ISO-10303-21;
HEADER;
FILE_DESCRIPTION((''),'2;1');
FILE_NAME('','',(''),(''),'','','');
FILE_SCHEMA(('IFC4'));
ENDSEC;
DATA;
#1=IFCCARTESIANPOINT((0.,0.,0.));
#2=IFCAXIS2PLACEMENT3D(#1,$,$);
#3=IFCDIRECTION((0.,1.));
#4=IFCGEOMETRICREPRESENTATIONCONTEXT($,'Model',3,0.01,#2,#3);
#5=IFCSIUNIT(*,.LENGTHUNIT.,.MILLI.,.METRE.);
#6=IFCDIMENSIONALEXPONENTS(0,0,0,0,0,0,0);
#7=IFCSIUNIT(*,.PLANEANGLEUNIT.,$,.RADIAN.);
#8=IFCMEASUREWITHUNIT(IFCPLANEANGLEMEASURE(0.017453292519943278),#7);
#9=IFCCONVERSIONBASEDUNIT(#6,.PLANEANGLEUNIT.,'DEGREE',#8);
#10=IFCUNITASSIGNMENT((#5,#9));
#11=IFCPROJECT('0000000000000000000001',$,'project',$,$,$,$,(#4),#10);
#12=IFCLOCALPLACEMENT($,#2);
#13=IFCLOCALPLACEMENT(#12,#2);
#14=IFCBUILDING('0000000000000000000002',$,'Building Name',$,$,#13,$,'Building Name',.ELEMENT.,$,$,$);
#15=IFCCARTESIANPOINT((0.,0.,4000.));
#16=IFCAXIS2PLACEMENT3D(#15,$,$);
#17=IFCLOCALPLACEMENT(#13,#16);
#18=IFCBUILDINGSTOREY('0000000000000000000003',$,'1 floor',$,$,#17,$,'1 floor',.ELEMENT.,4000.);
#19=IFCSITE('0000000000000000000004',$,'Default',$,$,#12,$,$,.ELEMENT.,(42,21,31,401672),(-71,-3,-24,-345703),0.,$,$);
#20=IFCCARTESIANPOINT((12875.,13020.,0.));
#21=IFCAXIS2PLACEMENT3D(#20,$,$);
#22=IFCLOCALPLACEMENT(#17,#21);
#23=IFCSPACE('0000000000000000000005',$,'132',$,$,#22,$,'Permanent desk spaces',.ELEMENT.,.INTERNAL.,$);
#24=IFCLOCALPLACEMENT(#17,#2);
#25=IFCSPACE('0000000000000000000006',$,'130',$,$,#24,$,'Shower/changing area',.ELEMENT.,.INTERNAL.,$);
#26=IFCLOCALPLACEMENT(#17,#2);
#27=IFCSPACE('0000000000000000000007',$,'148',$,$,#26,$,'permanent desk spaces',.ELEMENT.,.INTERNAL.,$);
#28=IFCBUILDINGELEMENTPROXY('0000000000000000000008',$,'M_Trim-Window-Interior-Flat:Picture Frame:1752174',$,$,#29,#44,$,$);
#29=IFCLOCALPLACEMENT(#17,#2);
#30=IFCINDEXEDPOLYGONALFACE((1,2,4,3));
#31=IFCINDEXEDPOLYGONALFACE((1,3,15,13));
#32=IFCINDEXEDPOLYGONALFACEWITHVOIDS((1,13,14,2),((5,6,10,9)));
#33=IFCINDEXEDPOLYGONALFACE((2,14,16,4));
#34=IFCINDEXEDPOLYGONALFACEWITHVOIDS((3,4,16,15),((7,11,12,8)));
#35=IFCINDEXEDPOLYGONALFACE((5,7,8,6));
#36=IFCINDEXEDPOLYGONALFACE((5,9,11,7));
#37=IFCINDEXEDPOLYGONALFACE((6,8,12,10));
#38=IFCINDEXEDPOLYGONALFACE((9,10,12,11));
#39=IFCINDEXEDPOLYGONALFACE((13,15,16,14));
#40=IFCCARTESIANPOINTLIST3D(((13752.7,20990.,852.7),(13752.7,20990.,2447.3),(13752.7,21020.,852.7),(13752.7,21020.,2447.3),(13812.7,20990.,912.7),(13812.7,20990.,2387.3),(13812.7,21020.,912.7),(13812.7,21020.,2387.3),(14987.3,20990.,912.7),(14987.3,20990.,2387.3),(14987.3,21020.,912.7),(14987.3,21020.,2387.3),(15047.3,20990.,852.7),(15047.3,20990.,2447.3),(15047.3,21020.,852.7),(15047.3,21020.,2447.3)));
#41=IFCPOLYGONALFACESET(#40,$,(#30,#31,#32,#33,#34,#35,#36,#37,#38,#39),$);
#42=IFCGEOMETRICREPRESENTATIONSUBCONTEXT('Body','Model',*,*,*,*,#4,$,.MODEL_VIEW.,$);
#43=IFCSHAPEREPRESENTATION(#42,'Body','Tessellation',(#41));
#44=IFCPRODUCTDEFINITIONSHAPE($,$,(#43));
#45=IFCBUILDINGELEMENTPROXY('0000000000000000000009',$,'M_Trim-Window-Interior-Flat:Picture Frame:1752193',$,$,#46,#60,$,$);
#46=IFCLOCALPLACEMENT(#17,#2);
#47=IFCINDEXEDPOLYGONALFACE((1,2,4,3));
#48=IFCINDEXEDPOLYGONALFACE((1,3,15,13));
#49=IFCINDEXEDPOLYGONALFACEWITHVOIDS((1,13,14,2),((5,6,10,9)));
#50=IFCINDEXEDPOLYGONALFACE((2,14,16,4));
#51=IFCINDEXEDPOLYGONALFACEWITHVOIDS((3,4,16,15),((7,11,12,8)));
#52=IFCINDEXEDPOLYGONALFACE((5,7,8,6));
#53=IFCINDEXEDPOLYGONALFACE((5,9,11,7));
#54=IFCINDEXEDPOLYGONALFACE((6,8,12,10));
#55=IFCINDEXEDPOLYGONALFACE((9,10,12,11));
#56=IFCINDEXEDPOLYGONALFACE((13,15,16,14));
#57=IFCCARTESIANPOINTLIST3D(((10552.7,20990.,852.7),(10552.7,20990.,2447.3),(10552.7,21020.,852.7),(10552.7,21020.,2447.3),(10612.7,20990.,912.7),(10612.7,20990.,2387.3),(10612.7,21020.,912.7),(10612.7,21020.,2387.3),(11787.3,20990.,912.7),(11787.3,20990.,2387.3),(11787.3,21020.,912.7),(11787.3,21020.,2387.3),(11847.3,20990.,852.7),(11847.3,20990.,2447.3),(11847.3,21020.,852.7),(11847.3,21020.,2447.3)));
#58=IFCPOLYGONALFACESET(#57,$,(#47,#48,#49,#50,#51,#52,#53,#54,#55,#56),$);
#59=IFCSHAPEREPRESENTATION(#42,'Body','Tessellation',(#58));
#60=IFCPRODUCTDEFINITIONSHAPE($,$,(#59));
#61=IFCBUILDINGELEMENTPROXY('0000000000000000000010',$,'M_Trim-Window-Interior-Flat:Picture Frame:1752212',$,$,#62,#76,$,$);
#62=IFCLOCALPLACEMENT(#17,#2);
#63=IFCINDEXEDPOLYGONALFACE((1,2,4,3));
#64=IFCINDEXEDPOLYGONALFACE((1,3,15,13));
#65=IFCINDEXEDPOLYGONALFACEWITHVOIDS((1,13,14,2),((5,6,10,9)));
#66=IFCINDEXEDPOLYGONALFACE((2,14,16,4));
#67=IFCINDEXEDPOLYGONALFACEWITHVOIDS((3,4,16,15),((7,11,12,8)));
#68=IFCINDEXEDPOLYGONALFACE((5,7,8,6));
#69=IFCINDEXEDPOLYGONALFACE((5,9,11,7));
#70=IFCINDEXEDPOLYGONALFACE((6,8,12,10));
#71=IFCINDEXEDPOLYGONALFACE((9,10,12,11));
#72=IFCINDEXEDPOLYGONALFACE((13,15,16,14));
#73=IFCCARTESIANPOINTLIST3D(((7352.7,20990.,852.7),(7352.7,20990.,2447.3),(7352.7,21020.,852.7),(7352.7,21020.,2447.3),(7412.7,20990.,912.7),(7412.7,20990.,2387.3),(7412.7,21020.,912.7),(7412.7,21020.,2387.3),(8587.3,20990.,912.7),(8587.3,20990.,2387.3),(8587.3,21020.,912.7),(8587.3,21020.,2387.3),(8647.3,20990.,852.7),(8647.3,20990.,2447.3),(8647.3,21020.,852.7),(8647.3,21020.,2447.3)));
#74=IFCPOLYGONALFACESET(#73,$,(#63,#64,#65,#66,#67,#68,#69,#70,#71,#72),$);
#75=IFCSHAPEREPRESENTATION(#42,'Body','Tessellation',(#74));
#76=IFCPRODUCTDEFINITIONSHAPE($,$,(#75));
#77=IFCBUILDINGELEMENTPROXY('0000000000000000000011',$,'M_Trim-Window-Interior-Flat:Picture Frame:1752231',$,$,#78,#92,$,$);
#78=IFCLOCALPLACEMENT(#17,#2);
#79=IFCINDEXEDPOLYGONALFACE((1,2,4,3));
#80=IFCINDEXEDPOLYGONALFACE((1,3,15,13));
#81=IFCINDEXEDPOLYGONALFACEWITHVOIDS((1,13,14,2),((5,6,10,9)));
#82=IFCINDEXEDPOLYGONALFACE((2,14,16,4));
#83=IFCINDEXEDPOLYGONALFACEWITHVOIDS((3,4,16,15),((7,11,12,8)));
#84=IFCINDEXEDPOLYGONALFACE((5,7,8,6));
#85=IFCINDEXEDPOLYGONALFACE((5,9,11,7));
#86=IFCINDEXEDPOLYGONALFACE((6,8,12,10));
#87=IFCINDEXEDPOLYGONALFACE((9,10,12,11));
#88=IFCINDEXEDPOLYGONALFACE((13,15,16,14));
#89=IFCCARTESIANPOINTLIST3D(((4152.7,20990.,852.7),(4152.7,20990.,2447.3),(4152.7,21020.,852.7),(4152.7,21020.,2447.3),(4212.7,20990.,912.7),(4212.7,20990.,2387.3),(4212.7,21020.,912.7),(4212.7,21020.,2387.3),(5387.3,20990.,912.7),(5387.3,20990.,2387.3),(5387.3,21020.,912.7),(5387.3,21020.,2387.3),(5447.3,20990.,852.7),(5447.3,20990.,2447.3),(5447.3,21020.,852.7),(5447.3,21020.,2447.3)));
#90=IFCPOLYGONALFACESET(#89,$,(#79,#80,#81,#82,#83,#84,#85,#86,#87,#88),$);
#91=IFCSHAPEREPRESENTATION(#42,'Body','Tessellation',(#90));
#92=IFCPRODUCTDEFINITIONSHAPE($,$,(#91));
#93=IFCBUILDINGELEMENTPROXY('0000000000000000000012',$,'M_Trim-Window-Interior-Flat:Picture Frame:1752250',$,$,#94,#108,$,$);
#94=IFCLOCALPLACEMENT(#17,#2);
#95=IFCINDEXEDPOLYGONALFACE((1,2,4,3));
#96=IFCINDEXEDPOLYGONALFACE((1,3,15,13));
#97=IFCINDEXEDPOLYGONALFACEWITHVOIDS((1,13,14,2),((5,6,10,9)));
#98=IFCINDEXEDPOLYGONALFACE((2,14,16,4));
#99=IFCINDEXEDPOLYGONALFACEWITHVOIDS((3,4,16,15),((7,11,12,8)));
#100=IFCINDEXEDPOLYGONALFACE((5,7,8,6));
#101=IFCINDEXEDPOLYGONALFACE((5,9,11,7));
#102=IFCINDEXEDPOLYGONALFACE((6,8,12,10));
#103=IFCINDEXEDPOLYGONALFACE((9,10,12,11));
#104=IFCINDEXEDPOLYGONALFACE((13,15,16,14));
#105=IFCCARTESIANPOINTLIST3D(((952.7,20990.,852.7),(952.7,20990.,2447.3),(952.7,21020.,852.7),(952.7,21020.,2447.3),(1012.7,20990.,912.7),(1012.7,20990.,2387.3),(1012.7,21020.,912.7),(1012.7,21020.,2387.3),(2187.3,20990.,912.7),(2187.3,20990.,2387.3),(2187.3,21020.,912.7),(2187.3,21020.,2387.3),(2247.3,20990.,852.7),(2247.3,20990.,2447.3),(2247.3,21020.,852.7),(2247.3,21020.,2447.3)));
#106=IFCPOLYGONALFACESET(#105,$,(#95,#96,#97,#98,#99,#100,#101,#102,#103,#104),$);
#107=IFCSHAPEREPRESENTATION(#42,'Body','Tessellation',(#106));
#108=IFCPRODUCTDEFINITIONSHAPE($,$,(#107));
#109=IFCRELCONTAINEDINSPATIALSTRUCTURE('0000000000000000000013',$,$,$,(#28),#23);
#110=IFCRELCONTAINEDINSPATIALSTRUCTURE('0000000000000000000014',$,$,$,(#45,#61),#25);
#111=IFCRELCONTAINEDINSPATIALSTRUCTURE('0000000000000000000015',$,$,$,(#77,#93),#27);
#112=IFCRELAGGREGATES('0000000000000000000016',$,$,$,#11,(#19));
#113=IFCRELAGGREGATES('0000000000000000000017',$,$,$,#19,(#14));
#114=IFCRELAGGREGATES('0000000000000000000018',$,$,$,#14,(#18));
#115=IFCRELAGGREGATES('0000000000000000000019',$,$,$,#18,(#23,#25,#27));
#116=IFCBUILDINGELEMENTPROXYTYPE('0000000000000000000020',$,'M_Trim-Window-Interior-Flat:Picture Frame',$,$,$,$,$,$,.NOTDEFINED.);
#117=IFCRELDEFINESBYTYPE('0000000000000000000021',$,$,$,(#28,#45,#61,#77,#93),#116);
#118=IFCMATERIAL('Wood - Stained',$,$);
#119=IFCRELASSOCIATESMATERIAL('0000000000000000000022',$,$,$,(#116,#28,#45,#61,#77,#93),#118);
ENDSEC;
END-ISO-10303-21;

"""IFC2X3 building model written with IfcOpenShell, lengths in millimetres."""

from ifc_helpers import new_model, entity, si_unit, converted_unit, direction, frame, origin, place, context, subcontext, project, spatial, polyline, outline, extrude, source, transform, mapped, material, type_object, type_shapes, element, save


model = new_model("IFC2X3")

# Units and contexts
model_context = context("Model", 3, precision=0.01, world=origin(), true_north=direction((0.0, 1.0)))
body_context = subcontext(model_context, "Body", "Model", "MODEL_VIEW")
ifc_project = project(units=[si_unit("LENGTHUNIT", "METRE", prefix="MILLI"), converted_unit("PLANEANGLEUNIT", "DEGREE", entity("IfcPlaneAngleMeasure", 0.017453292519943278), si_unit("PLANEANGLEUNIT", "RADIAN"), dimensions=[0, 0, 0, 0, 0, 0, 0])], contexts=[model_context])

# Site, building, storey
site_placement = place(None, origin())
site = spatial("IfcSite", under=ifc_project, at=site_placement, Name="Default", CompositionType="ELEMENT", RefLatitude=(42, 21, 31, 401672), RefLongitude=(-71, -3, -24, -345703), RefElevation=0.0)
building_placement = place(site_placement, origin())
building = spatial("IfcBuilding", under=site, at=building_placement, Name="Building Name", LongName="Building Name", CompositionType="ELEMENT")
storey_placement = place(building_placement, frame((0.0, 0.0, 4000.0)))
storey = spatial("IfcBuildingStorey", under=building, at=storey_placement, Name="1 floor", LongName="1 floor", CompositionType="ELEMENT", Elevation=4000.0)

# Shared definitions
space_1_placement = place(storey_placement, frame((12875.0, 13020.0, 0.0)))
space_1 = spatial("IfcSpace", under=storey, at=space_1_placement, Name="132", LongName="Permanent desk spaces", CompositionType="ELEMENT", InteriorOrExteriorSpace="INTERNAL")

# Building element proxy
ifc_material_1 = material(Name="Wood - Stained")
building_element_proxy_type = type_object("IfcBuildingElementProxyType", Name="M_Trim-Window-Interior-Flat:Picture Frame", PredefinedType="NOTDEFINED", material=ifc_material_1)
shared_shape_1 = source(origin(), body_context, "Body", "SweptSolid", [
    extrude(outline(polyline([(-647.3, -797.3), (647.3, -797.3), (647.3, 797.3), (-647.3, 797.3), (-647.3, -797.3)]), holes=[polyline([(-587.3, -737.3), (-587.3, 737.3), (587.3, 737.3), (587.3, -737.3), (-587.3, -737.3)])]), frame((0.0, -750.0, 0.0), z_axis=(0.0, 0.0, 1.0), x_axis=(-1.0, 0.0, 0.0)), (0.0, 0.0, 1.0), 30.0),
])
type_shapes(building_element_proxy_type, [shared_shape_1])
for number, where, z_axis, x_axis, name in (
    (1, (1525.0, 8000.0, 2400.0), (0.0, -1.0, 0.0), (1.0, 0.0, 0.0), "M_Trim-Window-Interior-Flat:Picture Frame:1752174"),
):
    element("IfcBuildingElementProxy", number, at=place(space_1_placement, frame(where, z_axis=z_axis, x_axis=x_axis)), inside=space_1, type_object=building_element_proxy_type, material=ifc_material_1, Name=name, context=body_context, shape_type="MappedRepresentation", body=[
        mapped(shared_shape_1, transform((0.0, 0.0, 0.0), scale=1.0)),
    ])

# Shared definitions
space_2_placement = place(storey_placement, origin())
space_2 = spatial("IfcSpace", under=storey, at=space_2_placement, Name="130", LongName="Shower/changing area", CompositionType="ELEMENT", InteriorOrExteriorSpace="INTERNAL")

# Building element proxies
for number, where, z_axis, x_axis, name in (
    (2, (11200.0, 21020.0, 2400.0), (0.0, -1.0, 0.0), (1.0, 0.0, 0.0), "M_Trim-Window-Interior-Flat:Picture Frame:1752193"),
    (3, (8000.0, 21020.0, 2400.0), (0.0, -1.0, 0.0), (1.0, 0.0, 0.0), "M_Trim-Window-Interior-Flat:Picture Frame:1752212"),
):
    element("IfcBuildingElementProxy", number, at=place(space_2_placement, frame(where, z_axis=z_axis, x_axis=x_axis)), inside=space_2, type_object=building_element_proxy_type, material=ifc_material_1, Name=name, context=body_context, shape_type="MappedRepresentation", body=[
        mapped(shared_shape_1, transform((0.0, 0.0, 0.0), scale=1.0)),
    ])

# Shared definitions
space_3_placement = place(storey_placement, origin())
space_3 = spatial("IfcSpace", under=storey, at=space_3_placement, Name="148", LongName="permanent desk spaces", CompositionType="ELEMENT", InteriorOrExteriorSpace="INTERNAL")

# Building element proxies
for number, where, z_axis, x_axis, name in (
    (4, (4800.0, 21020.0, 2400.0), (0.0, -1.0, 0.0), (1.0, 0.0, 0.0), "M_Trim-Window-Interior-Flat:Picture Frame:1752231"),
    (5, (1600.0, 21020.0, 2400.0), (0.0, -1.0, 0.0), (1.0, 0.0, 0.0), "M_Trim-Window-Interior-Flat:Picture Frame:1752250"),
):
    element("IfcBuildingElementProxy", number, at=place(space_3_placement, frame(where, z_axis=z_axis, x_axis=x_axis)), inside=space_3, type_object=building_element_proxy_type, material=ifc_material_1, Name=name, context=body_context, shape_type="MappedRepresentation", body=[
        mapped(shared_shape_1, transform((0.0, 0.0, 0.0), scale=1.0)),
    ])

save(model, "model.ifc")
